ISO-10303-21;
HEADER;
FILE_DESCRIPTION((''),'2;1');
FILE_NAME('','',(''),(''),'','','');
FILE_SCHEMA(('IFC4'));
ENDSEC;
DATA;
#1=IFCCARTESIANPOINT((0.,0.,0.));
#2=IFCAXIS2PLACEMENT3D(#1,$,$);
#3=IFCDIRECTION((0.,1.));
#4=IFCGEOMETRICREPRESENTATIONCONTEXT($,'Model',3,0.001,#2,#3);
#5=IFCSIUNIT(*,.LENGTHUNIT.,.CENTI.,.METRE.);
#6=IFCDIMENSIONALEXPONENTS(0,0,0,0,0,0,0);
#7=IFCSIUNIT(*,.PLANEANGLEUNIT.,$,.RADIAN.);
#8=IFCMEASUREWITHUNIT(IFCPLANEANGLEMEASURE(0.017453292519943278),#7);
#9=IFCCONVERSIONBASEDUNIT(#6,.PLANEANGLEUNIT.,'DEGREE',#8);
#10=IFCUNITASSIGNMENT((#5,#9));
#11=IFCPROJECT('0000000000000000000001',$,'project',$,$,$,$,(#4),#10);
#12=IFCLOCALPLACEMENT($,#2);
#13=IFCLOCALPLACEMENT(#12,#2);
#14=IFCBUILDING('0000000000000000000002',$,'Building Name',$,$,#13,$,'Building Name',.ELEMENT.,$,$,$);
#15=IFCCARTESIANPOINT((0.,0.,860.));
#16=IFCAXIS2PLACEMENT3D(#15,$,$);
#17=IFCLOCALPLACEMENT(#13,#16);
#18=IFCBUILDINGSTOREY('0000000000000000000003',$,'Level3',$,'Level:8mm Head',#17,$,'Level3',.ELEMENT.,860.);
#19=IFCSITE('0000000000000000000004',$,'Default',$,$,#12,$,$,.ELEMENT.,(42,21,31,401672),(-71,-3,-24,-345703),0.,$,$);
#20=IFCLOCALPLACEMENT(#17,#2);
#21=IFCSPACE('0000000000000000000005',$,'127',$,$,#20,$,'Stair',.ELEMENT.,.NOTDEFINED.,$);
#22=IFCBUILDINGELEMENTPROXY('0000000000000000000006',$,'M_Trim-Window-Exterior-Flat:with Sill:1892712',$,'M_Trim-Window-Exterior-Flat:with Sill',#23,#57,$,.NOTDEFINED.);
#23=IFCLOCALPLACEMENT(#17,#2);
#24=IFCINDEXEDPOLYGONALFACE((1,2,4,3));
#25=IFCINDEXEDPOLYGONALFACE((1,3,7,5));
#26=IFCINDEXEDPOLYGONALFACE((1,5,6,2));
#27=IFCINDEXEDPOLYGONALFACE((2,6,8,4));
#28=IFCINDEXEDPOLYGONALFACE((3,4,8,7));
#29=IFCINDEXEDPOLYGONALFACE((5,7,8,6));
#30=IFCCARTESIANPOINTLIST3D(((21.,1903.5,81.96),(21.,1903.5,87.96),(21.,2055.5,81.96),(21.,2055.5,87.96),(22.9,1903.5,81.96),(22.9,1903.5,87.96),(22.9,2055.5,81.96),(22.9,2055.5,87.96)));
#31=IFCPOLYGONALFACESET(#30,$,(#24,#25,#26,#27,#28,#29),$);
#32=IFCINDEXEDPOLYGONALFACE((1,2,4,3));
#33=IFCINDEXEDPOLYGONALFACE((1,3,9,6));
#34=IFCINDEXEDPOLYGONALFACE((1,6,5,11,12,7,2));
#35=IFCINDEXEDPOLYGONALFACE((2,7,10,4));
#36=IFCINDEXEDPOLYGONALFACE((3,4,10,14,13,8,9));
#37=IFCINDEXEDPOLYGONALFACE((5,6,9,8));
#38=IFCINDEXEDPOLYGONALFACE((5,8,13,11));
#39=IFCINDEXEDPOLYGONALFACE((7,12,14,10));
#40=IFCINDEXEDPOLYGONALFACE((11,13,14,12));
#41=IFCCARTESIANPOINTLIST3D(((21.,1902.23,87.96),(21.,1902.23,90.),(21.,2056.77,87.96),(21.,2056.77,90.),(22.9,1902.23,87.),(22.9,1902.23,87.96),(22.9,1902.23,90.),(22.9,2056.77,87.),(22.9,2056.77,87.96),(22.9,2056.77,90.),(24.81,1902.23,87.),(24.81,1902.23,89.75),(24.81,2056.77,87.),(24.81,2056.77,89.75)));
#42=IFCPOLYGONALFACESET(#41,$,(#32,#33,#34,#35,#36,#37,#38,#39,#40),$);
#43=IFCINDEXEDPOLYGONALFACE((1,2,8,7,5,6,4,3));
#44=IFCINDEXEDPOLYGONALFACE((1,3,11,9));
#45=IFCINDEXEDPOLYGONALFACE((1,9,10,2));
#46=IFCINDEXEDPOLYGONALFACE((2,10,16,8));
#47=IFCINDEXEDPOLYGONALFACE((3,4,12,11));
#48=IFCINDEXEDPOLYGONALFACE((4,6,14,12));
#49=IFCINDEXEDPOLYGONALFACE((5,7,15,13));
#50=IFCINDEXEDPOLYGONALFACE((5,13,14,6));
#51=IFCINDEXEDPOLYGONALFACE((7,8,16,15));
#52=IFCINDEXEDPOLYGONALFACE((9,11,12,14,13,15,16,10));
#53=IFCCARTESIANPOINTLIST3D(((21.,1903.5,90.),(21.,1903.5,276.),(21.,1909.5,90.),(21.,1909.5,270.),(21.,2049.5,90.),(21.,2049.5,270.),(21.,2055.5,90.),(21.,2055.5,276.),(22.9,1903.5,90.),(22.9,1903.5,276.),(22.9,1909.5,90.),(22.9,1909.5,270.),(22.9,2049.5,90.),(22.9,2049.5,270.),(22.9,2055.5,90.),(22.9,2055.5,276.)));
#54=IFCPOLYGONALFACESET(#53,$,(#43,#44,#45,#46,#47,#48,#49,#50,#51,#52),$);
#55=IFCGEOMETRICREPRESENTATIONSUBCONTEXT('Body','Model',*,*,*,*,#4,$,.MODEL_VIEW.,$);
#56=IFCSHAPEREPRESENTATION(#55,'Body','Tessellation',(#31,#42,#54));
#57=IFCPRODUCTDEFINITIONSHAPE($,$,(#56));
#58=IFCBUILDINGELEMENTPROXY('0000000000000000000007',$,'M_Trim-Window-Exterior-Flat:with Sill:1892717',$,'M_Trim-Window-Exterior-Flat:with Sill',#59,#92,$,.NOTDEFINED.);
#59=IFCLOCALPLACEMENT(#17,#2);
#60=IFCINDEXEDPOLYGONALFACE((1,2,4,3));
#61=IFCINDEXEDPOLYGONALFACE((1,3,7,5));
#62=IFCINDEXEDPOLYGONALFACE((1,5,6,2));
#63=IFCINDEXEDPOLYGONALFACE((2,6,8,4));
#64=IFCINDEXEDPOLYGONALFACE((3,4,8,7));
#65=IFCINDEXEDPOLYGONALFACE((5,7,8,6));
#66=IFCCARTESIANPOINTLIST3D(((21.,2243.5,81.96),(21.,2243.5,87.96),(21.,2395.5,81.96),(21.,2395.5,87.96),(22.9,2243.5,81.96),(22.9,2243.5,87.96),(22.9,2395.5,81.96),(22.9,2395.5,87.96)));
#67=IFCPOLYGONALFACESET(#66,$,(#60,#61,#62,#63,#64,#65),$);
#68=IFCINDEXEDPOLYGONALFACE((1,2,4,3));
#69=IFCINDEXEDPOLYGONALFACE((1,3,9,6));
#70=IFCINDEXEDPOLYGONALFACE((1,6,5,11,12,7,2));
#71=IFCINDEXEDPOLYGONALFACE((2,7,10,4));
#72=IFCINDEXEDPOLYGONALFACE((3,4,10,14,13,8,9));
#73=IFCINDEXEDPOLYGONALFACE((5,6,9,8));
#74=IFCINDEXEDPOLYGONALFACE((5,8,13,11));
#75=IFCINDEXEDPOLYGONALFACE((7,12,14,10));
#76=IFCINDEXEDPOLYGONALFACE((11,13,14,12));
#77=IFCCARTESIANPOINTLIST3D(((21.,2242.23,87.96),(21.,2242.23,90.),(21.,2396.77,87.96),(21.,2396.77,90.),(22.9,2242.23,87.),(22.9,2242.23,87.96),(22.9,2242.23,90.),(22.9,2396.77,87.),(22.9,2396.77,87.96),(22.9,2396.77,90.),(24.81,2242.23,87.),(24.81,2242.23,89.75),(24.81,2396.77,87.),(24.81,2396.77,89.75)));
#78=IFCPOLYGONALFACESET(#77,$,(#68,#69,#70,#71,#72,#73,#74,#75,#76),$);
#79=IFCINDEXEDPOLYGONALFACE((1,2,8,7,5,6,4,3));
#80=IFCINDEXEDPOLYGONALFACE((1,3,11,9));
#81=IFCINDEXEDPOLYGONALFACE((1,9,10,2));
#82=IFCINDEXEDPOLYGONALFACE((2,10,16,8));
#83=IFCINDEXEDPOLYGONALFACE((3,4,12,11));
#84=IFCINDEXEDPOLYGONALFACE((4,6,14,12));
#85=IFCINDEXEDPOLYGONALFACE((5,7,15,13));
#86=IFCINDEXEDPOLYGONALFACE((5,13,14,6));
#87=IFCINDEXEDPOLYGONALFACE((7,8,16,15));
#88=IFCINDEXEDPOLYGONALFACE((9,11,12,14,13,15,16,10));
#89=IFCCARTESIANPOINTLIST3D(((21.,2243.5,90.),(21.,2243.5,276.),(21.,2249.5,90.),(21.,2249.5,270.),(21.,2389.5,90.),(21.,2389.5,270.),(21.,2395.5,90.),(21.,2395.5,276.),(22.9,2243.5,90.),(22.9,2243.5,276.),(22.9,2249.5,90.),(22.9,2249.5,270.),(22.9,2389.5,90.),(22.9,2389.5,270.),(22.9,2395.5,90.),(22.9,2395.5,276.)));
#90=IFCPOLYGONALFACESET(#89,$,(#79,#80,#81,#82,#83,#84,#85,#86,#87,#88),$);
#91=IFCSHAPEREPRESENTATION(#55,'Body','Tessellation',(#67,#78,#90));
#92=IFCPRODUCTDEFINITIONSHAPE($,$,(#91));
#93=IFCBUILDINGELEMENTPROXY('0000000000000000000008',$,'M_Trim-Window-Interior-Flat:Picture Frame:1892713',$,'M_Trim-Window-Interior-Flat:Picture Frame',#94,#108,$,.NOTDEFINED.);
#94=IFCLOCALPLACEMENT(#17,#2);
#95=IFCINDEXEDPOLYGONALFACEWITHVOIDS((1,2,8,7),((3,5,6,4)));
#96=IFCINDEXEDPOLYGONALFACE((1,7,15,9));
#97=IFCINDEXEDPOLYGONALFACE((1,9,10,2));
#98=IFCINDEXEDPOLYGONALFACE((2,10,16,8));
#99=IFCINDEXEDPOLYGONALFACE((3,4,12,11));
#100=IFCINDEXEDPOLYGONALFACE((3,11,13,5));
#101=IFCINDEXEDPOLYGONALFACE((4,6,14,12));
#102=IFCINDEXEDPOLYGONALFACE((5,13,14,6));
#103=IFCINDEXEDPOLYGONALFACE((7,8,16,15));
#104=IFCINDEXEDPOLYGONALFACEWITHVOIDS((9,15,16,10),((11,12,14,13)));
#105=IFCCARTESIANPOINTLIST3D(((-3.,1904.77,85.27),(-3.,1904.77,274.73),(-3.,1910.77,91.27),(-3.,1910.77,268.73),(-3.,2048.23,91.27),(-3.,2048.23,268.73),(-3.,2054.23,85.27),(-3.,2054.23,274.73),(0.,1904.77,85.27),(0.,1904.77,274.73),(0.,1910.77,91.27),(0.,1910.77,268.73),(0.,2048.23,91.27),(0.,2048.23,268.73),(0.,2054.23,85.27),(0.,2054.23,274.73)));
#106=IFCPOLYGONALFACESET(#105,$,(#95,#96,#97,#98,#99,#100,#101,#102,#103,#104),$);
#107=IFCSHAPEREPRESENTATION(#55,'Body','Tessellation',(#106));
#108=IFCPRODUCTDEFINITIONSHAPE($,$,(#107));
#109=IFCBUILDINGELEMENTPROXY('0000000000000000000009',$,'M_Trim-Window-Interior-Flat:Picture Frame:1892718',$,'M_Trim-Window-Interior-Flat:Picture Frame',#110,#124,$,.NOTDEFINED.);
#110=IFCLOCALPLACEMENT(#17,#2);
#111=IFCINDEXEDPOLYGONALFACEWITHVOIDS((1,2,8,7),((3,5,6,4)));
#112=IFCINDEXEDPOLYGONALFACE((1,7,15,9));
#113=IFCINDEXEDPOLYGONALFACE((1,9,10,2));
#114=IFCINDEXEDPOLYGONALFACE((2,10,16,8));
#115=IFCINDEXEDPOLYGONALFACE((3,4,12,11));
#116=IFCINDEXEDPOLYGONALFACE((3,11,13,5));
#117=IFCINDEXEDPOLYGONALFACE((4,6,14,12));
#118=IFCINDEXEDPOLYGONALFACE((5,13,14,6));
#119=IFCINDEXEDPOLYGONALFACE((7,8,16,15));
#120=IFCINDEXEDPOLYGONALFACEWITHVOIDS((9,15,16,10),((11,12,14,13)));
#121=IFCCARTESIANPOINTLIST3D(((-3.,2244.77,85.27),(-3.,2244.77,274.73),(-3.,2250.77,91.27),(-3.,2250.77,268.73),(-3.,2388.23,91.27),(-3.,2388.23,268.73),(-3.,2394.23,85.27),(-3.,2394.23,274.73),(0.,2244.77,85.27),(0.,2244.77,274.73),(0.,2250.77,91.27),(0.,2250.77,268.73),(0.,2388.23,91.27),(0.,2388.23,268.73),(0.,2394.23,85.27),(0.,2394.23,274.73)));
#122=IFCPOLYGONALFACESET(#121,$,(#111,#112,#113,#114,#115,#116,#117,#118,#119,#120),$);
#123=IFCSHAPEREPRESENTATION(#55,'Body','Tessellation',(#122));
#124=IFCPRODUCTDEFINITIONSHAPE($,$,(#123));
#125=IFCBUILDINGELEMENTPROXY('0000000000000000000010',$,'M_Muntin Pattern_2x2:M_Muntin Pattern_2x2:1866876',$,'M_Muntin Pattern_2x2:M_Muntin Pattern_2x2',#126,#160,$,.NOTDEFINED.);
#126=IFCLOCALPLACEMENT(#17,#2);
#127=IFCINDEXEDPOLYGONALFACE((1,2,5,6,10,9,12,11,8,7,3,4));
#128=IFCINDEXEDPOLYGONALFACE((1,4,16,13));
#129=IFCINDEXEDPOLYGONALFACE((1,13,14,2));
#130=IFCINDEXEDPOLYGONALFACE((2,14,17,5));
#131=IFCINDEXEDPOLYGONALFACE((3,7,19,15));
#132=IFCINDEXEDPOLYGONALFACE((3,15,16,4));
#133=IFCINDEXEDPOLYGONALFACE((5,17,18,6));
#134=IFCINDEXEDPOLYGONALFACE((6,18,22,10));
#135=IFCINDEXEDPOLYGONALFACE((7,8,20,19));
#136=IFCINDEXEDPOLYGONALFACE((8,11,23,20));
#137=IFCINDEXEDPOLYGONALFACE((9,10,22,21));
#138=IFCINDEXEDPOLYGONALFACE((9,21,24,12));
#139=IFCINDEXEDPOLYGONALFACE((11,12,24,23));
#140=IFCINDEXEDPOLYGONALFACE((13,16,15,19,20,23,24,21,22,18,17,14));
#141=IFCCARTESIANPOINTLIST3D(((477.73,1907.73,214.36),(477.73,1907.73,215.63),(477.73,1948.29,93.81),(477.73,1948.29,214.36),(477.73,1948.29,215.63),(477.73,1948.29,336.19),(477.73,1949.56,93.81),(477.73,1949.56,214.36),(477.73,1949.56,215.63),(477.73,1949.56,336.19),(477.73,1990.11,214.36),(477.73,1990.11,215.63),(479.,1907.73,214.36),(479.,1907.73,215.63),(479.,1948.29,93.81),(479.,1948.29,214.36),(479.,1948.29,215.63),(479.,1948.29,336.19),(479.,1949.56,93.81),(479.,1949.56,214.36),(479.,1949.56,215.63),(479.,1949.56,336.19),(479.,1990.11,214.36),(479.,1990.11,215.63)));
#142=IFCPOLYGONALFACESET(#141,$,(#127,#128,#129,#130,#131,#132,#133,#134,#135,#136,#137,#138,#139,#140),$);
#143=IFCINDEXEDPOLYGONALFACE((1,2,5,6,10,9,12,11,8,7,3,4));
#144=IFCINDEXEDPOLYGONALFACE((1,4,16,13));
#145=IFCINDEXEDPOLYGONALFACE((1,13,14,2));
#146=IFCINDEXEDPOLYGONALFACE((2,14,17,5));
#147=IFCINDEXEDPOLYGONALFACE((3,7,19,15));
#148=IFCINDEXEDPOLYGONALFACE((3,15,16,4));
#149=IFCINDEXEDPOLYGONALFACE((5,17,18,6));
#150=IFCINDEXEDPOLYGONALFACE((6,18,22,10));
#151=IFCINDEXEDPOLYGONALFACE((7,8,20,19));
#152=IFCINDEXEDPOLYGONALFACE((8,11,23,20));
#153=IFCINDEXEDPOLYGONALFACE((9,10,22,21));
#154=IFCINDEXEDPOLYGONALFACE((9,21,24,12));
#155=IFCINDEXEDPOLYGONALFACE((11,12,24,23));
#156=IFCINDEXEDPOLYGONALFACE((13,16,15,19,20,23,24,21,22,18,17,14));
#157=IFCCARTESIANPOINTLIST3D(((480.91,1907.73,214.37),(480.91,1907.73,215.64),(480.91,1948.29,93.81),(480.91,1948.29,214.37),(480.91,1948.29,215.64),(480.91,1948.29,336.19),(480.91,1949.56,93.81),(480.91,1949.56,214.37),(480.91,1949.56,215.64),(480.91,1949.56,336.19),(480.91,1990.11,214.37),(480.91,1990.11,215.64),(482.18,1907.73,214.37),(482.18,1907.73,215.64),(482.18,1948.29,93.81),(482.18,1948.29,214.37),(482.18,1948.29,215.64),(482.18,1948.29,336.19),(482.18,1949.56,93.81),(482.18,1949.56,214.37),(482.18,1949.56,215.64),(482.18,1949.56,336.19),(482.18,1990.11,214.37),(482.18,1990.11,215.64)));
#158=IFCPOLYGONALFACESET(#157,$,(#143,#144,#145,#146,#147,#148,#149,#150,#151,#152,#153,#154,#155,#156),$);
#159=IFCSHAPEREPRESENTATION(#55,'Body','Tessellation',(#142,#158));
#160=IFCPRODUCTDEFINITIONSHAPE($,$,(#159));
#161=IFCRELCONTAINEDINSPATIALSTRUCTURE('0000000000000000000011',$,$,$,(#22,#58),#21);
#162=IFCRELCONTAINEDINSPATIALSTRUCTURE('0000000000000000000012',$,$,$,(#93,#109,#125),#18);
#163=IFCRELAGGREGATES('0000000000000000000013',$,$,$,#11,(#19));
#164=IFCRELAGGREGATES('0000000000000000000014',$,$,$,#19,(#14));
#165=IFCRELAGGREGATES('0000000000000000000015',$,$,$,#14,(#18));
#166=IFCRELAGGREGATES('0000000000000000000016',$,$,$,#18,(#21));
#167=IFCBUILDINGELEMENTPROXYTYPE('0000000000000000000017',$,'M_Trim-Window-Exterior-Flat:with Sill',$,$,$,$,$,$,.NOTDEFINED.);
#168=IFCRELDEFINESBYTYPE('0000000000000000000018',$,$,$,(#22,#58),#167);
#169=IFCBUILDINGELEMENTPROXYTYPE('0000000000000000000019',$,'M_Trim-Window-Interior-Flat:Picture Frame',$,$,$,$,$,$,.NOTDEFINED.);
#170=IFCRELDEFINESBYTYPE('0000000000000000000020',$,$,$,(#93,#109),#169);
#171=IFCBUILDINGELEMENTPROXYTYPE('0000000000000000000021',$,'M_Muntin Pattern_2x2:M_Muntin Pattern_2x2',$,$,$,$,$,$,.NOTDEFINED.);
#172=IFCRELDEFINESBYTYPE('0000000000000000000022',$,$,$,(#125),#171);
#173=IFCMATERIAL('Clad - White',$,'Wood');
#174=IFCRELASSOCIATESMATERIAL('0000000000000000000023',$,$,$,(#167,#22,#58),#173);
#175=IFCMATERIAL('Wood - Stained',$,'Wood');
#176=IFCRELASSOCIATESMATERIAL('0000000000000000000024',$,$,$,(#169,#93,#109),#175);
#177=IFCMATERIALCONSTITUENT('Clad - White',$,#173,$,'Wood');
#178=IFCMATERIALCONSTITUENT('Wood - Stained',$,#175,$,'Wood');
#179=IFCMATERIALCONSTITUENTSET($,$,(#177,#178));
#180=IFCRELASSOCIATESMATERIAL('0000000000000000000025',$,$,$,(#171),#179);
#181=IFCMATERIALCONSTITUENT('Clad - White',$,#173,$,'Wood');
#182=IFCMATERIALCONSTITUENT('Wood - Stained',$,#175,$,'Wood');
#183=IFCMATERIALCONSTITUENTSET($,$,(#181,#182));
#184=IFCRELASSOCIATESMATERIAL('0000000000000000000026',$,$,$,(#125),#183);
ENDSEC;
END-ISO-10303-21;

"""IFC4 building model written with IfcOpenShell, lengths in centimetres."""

from ifc_helpers import new_model, entity, si_unit, converted_unit, direction, frame, origin, place, context, subcontext, project, spatial, indexed_curve, outline, extrude, source, transform, mapped, material, constituent, constituent_set, type_object, type_shapes, element, save


model = new_model("IFC4")

# Units and contexts
model_context = context("Model", 3, precision=0.001, world=origin(), true_north=direction((0.0, 1.0)))
body_context = subcontext(model_context, "Body", "Model", "MODEL_VIEW")
ifc_project = project(units=[si_unit("LENGTHUNIT", "METRE", prefix="CENTI"), converted_unit("PLANEANGLEUNIT", "DEGREE", entity("IfcPlaneAngleMeasure", 0.017453292519943278), si_unit("PLANEANGLEUNIT", "RADIAN"), dimensions=[0, 0, 0, 0, 0, 0, 0])], contexts=[model_context])

# Site, building, storey
site_placement = place(None, origin())
site = spatial("IfcSite", under=ifc_project, at=site_placement, Name="Default", CompositionType="ELEMENT", RefLatitude=(42, 21, 31, 401672), RefLongitude=(-71, -3, -24, -345703), RefElevation=0.0)
building_placement = place(site_placement, origin())
building = spatial("IfcBuilding", under=site, at=building_placement, Name="Building Name", LongName="Building Name", CompositionType="ELEMENT")
storey_placement = place(building_placement, frame((0.0, 0.0, 860.0)))
storey = spatial("IfcBuildingStorey", under=building, at=storey_placement, Name="Level3", ObjectType="Level:8mm Head", LongName="Level3", CompositionType="ELEMENT", Elevation=860.0)

# Shared definitions
ifc_material_1 = material(Name="Clad - White", Category="Wood")
ifc_material_2 = material(Name="Wood - Stained", Category="Wood")

# Shared definitions
space_1_placement = place(storey_placement, origin())
space_1 = spatial("IfcSpace", under=storey, at=space_1_placement, Name="127", LongName="Stair", CompositionType="ELEMENT", PredefinedType="NOTDEFINED")

# Building element proxies
building_element_proxy_type_1 = type_object("IfcBuildingElementProxyType", Name="M_Trim-Window-Exterior-Flat:with Sill", PredefinedType="NOTDEFINED", material=ifc_material_1)
shared_shape_1 = source(origin(), body_context, "Body", "SweptSolid", [
    extrude(outline(indexed_curve([(-76.0, -3.0), (76.0, -3.0), (76.0, 3.0), (-76.0, 3.0), (-76.0, -3.0)], self_intersect=False)), frame((0.0, -185.04, 0.0), z_axis=(0.0, 0.0, 1.0), x_axis=(-1.0, 0.0, 0.0)), (0.0, 0.0, 1.0), 1.9),
    extrude(outline(indexed_curve([(-1.9, -1.52), (0.0, -1.52), (0.0, -0.57), (1.9, -0.57), (1.9, 1.48), (0.0, 1.48), (-1.9, 1.23), (-1.9, -1.52)], self_intersect=False)), frame((-77.27, -181.48, 1.9), z_axis=(1.0, 0.0, 0.0), x_axis=(0.0, 0.0, -1.0)), (0.0, 0.0, 1.0), 154.54),
    extrude(outline(indexed_curve([(-94.5, -76.0), (91.5, -76.0), (91.5, -70.0), (-88.5, -70.0), (-88.5, 70.0), (91.5, 70.0), (91.5, 76.0), (-94.5, 76.0), (-94.5, -76.0)], self_intersect=False)), frame((0.0, -88.5, 0.0), z_axis=(0.0, 0.0, 1.0), x_axis=(0.0, -1.0, 0.0)), (0.0, 0.0, 1.0), 1.9),
])
type_shapes(building_element_proxy_type_1, [shared_shape_1])
for number, where, z_axis, x_axis, name in (
    (1, (21.0, 1979.5, 270.0), (1.0, 0.0, 0.0), (0.0, 1.0, 0.0), "M_Trim-Window-Exterior-Flat:with Sill:1892712"),
    (2, (21.0, 2319.5, 270.0), (1.0, 0.0, 0.0), (0.0, 1.0, 0.0), "M_Trim-Window-Exterior-Flat:with Sill:1892717"),
):
    element("IfcBuildingElementProxy", number, at=place(space_1_placement, frame(where, z_axis=z_axis, x_axis=x_axis)), inside=space_1, type_object=building_element_proxy_type_1, material=ifc_material_1, Name=name, ObjectType="M_Trim-Window-Exterior-Flat:with Sill", PredefinedType="NOTDEFINED", context=body_context, shape_type="MappedRepresentation", body=[
        mapped(shared_shape_1, transform((0.0, 0.0, 0.0), scale=1.0)),
    ])
building_element_proxy_type_2 = type_object("IfcBuildingElementProxyType", Name="M_Trim-Window-Interior-Flat:Picture Frame", PredefinedType="NOTDEFINED", material=ifc_material_2)
shared_shape_2 = source(origin(), body_context, "Body", "SweptSolid", [
    extrude(outline(indexed_curve([(-74.73, -94.73), (74.73, -94.73), (74.73, 94.73), (-74.73, 94.73), (-74.73, -94.73)], self_intersect=False), holes=[indexed_curve([(-68.73, -88.73), (-68.73, 88.73), (68.73, 88.73), (68.73, -88.73), (-68.73, -88.73)], self_intersect=False)]), frame((0.0, -90.0, 0.0), z_axis=(0.0, 0.0, 1.0), x_axis=(-1.0, 0.0, 0.0)), (0.0, 0.0, 1.0), 3.0),
])
type_shapes(building_element_proxy_type_2, [shared_shape_2])
for number, where, z_axis, x_axis, name in (
    (3, (0.0, 1979.5, 270.0), (-1.0, 0.0, 0.0), (0.0, -1.0, 0.0), "M_Trim-Window-Interior-Flat:Picture Frame:1892713"),
    (4, (0.0, 2319.5, 270.0), (-1.0, 0.0, 0.0), (0.0, -1.0, 0.0), "M_Trim-Window-Interior-Flat:Picture Frame:1892718"),
):
    element("IfcBuildingElementProxy", number, at=place(storey_placement, frame(where, z_axis=z_axis, x_axis=x_axis)), inside=storey, type_object=building_element_proxy_type_2, material=ifc_material_2, Name=name, ObjectType="M_Trim-Window-Interior-Flat:Picture Frame", PredefinedType="NOTDEFINED", context=body_context, shape_type="MappedRepresentation", body=[
        mapped(shared_shape_2, transform((0.0, 0.0, 0.0), scale=1.0)),
    ])
ifc_constituent_1 = constituent(ifc_material_1, Name="Clad - White", Category="Wood")
ifc_constituent_2 = constituent(ifc_material_2, Name="Wood - Stained", Category="Wood")
ifc_constituent_set_1 = constituent_set(constituents=[ifc_constituent_1, ifc_constituent_2])
ifc_constituent_3 = constituent(ifc_material_1, Name="Clad - White", Category="Wood")
ifc_constituent_4 = constituent(ifc_material_2, Name="Wood - Stained", Category="Wood")
ifc_constituent_set_2 = constituent_set(constituents=[ifc_constituent_3, ifc_constituent_4])
building_element_proxy_type_3 = type_object("IfcBuildingElementProxyType", Name="M_Muntin Pattern_2x2:M_Muntin Pattern_2x2", PredefinedType="NOTDEFINED", material=ifc_constituent_set_2)
shared_shape_3 = source(origin(), body_context, "Body", "SweptSolid", [
    extrude(outline(indexed_curve([(0.64, -0.64), (121.19, -0.64), (121.19, 0.63), (0.64, 0.63), (0.64, 41.19), (-0.63, 41.19), (-0.63, 0.63), (-121.19, 0.63), (-121.19, -0.64), (-0.63, -0.64), (-0.63, -41.19), (0.64, -41.19), (0.64, -0.64)], self_intersect=False)), frame((0.0, -2.22, 121.19), z_axis=(0.0, 1.0, 0.0), x_axis=(0.0, 0.0, 1.0)), (0.0, 0.0, 1.0), 1.27),
    extrude(outline(indexed_curve([(0.64, -0.64), (121.19, -0.64), (121.19, 0.63), (0.64, 0.63), (0.64, 41.19), (-0.63, 41.19), (-0.63, 0.63), (-121.19, 0.63), (-121.19, -0.64), (-0.63, -0.64), (-0.63, -41.19), (0.64, -41.19), (0.64, -0.64)], self_intersect=False)), frame((0.0, 0.95, 121.19), z_axis=(0.0, 1.0, 0.0), x_axis=(0.0, 0.0, 1.0)), (0.0, 0.0, 1.0), 1.27),
])
type_shapes(building_element_proxy_type_3, [shared_shape_3])
proxy_1_placement = place(storey_placement, frame((479.95, 1948.92, 93.81), z_axis=(0.0, 0.0, 1.0), x_axis=(0.0, -1.0, 0.0)))
element("IfcBuildingElementProxy", 5, at=proxy_1_placement, inside=storey, type_object=building_element_proxy_type_3, material=ifc_constituent_set_1, Name="M_Muntin Pattern_2x2:M_Muntin Pattern_2x2:1866876", ObjectType="M_Muntin Pattern_2x2:M_Muntin Pattern_2x2", PredefinedType="NOTDEFINED", context=body_context, shape_type="MappedRepresentation", body=[
    mapped(shared_shape_3, transform((0.0, 0.0, 0.0), scale=1.0)),
])

save(model, "model.ifc")
